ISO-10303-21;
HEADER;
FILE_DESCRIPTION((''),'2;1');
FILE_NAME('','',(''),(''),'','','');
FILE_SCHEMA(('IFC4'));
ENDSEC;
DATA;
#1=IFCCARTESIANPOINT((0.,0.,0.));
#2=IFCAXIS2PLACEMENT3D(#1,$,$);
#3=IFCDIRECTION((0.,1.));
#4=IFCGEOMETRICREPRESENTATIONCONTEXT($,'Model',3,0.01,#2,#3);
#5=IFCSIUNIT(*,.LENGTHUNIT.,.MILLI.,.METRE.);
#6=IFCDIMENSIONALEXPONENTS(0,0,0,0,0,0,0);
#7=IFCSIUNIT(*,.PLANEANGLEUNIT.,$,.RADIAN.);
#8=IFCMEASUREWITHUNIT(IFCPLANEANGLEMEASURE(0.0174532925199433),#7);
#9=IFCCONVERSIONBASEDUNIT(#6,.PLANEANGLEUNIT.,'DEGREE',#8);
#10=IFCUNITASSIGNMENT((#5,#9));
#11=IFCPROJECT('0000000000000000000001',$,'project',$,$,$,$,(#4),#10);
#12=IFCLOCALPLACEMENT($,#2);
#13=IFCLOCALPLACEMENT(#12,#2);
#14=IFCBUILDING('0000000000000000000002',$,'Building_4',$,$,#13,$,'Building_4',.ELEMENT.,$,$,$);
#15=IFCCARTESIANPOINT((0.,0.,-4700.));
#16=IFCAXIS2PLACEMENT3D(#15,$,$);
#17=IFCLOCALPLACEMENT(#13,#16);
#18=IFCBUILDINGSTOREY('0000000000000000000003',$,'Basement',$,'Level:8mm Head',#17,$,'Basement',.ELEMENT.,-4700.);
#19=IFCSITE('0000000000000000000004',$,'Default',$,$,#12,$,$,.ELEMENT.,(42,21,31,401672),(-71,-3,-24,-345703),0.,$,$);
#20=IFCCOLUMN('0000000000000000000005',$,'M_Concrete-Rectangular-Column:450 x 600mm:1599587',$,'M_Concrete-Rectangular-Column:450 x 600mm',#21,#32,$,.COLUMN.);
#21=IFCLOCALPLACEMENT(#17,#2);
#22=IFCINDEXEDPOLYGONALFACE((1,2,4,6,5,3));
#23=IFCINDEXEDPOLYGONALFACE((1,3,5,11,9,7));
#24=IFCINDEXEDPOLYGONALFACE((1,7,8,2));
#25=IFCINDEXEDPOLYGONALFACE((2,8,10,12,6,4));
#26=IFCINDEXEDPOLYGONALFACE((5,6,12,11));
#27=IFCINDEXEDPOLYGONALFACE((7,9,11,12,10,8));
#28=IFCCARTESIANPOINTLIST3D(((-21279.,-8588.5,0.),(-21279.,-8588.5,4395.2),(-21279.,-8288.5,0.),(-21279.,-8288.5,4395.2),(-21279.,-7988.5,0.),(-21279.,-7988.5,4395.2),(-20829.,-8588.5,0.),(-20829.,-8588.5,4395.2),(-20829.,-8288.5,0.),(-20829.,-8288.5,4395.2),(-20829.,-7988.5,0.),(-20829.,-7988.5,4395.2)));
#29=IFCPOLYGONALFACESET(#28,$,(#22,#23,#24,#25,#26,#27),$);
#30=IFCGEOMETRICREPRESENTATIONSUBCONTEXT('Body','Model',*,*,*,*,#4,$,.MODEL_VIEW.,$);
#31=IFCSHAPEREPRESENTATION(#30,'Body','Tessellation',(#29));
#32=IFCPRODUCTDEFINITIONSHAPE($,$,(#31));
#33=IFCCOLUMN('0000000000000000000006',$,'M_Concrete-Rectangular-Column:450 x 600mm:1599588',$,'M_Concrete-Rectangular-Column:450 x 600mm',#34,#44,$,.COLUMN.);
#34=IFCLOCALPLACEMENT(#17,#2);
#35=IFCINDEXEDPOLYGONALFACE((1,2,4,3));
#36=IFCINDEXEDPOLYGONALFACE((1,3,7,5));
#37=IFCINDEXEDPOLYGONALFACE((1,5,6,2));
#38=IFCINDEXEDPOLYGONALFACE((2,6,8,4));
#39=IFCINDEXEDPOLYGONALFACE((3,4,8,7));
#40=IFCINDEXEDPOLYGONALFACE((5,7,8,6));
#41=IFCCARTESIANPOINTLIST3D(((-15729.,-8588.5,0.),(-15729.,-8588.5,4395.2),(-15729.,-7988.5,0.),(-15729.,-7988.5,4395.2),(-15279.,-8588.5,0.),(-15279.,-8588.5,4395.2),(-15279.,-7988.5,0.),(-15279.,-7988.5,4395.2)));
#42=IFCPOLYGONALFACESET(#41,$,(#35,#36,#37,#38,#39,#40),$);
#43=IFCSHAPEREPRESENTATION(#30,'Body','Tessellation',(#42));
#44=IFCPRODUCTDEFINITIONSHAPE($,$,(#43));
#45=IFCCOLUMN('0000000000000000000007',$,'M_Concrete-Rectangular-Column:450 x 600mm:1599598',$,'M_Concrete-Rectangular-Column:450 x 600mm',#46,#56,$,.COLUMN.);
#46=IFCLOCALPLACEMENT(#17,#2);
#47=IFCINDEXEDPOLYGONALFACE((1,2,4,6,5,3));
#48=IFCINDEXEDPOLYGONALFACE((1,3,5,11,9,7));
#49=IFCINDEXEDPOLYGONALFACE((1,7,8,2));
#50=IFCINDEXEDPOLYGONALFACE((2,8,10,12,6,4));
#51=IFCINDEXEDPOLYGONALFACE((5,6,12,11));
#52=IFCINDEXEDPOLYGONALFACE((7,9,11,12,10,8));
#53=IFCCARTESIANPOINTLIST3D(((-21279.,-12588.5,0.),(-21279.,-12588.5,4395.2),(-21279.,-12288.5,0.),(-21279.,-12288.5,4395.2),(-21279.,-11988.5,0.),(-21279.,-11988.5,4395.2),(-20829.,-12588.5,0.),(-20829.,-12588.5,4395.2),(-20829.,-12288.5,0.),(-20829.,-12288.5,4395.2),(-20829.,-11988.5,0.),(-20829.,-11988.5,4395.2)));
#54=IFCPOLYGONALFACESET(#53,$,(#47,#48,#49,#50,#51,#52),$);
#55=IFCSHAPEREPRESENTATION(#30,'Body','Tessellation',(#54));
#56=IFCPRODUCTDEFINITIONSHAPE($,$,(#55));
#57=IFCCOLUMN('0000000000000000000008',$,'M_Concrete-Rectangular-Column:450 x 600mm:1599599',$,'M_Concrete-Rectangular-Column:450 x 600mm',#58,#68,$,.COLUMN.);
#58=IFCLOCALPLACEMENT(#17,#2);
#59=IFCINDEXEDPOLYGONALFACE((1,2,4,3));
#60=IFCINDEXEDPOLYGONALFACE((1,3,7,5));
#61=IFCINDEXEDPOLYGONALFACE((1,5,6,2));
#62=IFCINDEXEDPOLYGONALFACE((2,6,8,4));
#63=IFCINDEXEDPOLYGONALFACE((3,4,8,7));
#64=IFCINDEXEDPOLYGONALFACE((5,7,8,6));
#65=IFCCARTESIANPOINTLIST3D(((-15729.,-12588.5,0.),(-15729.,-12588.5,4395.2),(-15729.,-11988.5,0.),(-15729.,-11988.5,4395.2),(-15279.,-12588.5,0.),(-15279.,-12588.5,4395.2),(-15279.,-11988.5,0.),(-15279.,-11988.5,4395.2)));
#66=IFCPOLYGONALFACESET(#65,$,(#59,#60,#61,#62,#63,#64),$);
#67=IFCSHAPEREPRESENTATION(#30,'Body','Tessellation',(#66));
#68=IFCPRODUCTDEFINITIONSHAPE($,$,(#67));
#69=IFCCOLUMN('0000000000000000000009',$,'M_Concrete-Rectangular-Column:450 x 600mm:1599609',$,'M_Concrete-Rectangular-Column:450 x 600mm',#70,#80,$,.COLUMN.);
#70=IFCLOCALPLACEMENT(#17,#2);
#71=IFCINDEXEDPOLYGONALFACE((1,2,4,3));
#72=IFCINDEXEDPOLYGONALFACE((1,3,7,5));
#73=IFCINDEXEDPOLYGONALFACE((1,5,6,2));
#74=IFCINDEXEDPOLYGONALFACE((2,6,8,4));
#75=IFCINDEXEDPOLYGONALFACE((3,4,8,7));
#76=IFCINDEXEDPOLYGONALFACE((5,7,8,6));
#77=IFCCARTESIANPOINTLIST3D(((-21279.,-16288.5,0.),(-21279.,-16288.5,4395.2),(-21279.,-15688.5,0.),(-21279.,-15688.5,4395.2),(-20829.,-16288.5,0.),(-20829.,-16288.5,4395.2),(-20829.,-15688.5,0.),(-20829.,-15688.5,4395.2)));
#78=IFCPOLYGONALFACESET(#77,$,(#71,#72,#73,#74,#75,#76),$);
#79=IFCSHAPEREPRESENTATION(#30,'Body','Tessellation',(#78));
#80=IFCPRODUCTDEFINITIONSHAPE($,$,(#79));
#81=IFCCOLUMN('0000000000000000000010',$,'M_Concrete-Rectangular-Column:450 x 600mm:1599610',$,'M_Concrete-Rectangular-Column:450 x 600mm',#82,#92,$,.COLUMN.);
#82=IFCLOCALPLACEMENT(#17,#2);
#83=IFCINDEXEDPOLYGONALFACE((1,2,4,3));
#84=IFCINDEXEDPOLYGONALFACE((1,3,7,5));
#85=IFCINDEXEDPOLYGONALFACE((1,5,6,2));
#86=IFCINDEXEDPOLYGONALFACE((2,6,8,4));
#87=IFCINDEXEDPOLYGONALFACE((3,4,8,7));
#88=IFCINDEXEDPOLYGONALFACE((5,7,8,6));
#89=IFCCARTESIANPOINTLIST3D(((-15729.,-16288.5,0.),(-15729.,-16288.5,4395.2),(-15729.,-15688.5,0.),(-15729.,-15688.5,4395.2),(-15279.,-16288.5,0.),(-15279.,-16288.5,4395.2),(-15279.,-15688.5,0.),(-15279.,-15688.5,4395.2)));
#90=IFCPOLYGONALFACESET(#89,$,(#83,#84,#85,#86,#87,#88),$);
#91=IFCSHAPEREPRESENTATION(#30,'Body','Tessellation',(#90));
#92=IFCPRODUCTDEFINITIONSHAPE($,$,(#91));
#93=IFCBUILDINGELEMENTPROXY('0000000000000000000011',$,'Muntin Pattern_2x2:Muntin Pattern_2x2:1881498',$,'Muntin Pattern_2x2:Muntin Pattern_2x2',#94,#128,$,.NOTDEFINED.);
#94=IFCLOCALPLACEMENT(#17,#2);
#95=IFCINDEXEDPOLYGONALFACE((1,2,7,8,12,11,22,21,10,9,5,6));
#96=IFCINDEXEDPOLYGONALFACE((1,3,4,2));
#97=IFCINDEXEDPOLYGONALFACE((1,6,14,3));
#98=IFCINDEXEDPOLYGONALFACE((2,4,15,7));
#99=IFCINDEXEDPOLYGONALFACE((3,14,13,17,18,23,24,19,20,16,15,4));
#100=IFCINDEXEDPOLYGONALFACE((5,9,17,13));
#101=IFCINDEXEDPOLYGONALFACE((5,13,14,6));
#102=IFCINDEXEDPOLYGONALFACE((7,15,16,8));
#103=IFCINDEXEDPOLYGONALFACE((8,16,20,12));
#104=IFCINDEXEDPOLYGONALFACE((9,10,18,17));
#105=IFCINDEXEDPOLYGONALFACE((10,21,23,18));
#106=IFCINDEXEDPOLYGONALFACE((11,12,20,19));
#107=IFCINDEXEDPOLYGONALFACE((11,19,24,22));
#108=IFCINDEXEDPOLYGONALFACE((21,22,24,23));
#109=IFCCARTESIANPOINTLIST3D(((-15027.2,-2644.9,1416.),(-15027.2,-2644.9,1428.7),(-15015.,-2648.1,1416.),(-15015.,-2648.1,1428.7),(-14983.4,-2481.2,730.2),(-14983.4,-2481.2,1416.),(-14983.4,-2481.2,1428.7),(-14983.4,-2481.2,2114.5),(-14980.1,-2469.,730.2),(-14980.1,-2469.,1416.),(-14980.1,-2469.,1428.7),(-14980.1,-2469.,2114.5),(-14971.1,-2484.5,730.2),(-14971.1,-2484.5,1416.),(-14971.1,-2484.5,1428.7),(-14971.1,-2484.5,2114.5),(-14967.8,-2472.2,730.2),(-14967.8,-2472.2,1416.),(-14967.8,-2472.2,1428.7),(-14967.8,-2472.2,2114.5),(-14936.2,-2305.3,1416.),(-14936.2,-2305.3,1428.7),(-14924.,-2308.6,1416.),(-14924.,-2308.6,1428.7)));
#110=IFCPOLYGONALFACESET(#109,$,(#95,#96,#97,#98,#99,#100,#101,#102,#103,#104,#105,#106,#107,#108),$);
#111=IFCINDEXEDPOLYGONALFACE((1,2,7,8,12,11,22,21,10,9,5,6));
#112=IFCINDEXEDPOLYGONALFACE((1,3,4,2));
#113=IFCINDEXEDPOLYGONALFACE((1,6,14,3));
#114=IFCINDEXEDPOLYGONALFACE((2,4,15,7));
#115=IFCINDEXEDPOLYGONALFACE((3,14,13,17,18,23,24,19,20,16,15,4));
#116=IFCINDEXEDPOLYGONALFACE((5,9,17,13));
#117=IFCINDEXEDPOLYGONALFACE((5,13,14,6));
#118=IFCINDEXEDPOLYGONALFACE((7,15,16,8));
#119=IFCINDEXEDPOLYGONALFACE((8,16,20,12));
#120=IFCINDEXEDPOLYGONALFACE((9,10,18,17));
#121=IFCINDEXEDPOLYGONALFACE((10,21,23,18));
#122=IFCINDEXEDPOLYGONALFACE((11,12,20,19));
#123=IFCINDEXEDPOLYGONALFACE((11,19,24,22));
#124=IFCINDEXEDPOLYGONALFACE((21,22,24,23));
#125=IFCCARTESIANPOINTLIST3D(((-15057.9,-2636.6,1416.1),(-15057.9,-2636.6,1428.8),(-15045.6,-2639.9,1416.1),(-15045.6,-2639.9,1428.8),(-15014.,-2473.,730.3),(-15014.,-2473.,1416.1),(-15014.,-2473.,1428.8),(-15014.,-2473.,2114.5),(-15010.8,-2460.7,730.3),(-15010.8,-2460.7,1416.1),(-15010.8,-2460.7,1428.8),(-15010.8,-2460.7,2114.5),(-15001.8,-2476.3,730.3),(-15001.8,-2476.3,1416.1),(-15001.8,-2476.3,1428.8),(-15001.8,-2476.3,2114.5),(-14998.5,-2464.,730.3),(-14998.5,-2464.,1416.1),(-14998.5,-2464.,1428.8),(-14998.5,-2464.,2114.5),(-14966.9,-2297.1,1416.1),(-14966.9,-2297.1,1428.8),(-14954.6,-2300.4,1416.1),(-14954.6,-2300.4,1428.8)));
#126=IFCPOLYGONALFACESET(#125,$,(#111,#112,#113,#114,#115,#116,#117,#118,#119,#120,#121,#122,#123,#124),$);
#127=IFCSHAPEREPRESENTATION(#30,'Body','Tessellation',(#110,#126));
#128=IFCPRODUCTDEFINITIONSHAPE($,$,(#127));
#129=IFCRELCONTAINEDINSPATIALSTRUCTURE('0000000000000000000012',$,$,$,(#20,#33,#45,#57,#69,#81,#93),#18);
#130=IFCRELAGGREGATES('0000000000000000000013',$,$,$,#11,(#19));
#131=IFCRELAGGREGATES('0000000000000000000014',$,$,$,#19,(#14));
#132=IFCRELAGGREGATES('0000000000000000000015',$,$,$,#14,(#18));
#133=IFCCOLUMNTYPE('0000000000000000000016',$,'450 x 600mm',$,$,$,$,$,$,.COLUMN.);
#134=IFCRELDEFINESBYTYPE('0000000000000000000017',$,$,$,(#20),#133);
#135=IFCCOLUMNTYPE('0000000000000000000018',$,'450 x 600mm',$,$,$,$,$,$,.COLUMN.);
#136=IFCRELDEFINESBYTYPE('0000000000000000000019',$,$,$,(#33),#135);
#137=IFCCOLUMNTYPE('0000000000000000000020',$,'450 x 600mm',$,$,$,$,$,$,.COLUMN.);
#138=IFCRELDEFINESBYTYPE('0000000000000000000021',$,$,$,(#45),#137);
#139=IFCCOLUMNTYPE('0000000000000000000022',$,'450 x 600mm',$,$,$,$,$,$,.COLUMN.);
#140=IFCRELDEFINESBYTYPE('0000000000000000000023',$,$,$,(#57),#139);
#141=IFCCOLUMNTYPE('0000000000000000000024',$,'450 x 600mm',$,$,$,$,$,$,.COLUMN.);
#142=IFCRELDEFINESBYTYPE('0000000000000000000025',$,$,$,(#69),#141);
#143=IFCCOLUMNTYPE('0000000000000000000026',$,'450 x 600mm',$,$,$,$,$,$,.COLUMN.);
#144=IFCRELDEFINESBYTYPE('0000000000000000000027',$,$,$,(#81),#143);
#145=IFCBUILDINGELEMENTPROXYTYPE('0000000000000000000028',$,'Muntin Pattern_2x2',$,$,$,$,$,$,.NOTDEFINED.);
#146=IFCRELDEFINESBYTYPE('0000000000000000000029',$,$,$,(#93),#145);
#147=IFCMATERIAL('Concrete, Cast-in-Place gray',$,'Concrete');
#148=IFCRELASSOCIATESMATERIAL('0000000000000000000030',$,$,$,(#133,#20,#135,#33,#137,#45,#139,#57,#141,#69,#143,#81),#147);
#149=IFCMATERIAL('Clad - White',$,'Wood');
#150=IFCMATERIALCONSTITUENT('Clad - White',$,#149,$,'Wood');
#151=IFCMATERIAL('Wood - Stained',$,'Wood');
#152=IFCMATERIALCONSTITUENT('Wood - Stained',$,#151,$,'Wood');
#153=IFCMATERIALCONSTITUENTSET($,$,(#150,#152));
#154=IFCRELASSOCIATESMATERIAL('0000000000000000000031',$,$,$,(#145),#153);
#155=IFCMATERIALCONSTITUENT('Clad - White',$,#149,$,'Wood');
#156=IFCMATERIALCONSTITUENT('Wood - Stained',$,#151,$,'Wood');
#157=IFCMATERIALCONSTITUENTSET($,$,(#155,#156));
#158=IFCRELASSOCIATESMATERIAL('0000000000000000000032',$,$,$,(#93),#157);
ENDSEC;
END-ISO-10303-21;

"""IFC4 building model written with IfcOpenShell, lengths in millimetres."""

from ifc_helpers import new_model, entity, si_unit, converted_unit, direction, frame, origin, place, context, subcontext, project, spatial, indexed_curve, outline, extrude, source, transform, mapped, material, constituent, constituent_set, type_object, type_shapes, element, save


model = new_model("IFC4")

# Units and contexts
model_context = context("Model", 3, precision=0.01, world=origin(), true_north=direction((0.0, 1.0)))
body_context = subcontext(model_context, "Body", "Model", "MODEL_VIEW")
ifc_project = project(units=[si_unit("LENGTHUNIT", "METRE", prefix="MILLI"), converted_unit("PLANEANGLEUNIT", "DEGREE", entity("IfcPlaneAngleMeasure", 0.0174532925199433), si_unit("PLANEANGLEUNIT", "RADIAN"), dimensions=[0, 0, 0, 0, 0, 0, 0])], contexts=[model_context])

# Site, building, storey
site_placement = place(None, origin())
site = spatial("IfcSite", under=ifc_project, at=site_placement, Name="Default", CompositionType="ELEMENT", RefLatitude=(42, 21, 31, 401672), RefLongitude=(-71, -3, -24, -345703), RefElevation=0.0)
building_placement = place(site_placement, origin())
building = spatial("IfcBuilding", under=site, at=building_placement, Name="Building_4", LongName="Building_4", CompositionType="ELEMENT")
storey_placement = place(building_placement, frame((0.0, 0.0, -4700.0)))
storey = spatial("IfcBuildingStorey", under=building, at=storey_placement, Name="Basement", ObjectType="Level:8mm Head", LongName="Basement", CompositionType="ELEMENT", Elevation=-4700.0)

# Shared definitions
ifc_material_1 = material(Name="Concrete, Cast-in-Place gray", Category="Concrete")

# Columns
column_type_1 = type_object("IfcColumnType", Name="450 x 600mm", PredefinedType="COLUMN", material=ifc_material_1)
shared_shape_1 = source(origin(), body_context, "Body", "SweptSolid", [
    extrude(outline(indexed_curve([(-2197.6, -300.0), (2197.6, -300.0), (2197.6, 0.0), (2197.6, 300.0), (-2197.6, 300.0), (-2197.6, 0.0), (-2197.6, -300.0)], self_intersect=False)), frame((-21279.0, -8288.5, -2502.4), z_axis=(1.0, 0.0, 0.0), x_axis=(0.0, 0.0, 1.0)), (0.0, 0.0, 1.0), 450.0),
])
type_shapes(column_type_1, [shared_shape_1])
column_1_placement = place(storey_placement, frame((0.0, 0.0, 4700.0)))
element("IfcColumn", 1, at=column_1_placement, inside=storey, type_object=column_type_1, material=ifc_material_1, Name="M_Concrete-Rectangular-Column:450 x 600mm:1599587", ObjectType="M_Concrete-Rectangular-Column:450 x 600mm", PredefinedType="COLUMN", context=body_context, shape_type="MappedRepresentation", body=[
    mapped(shared_shape_1, transform((0.0, 0.0, 0.0), scale=1.0)),
])
column_type_2 = type_object("IfcColumnType", Name="450 x 600mm", PredefinedType="COLUMN", material=ifc_material_1)
shared_shape_2 = source(origin(), body_context, "Body", "SweptSolid", [
    extrude(outline(indexed_curve([(-2197.6, -300.0), (2197.6, -300.0), (2197.6, 300.0), (-2197.6, 300.0), (-2197.6, -300.0)], self_intersect=False)), frame((-15729.0, -8288.5, -2502.4), z_axis=(1.0, 0.0, 0.0), x_axis=(0.0, 0.0, 1.0)), (0.0, 0.0, 1.0), 450.0),
])
type_shapes(column_type_2, [shared_shape_2])
column_2_placement = place(storey_placement, frame((0.0, 0.0, 4700.0)))
element("IfcColumn", 2, at=column_2_placement, inside=storey, type_object=column_type_2, material=ifc_material_1, Name="M_Concrete-Rectangular-Column:450 x 600mm:1599588", ObjectType="M_Concrete-Rectangular-Column:450 x 600mm", PredefinedType="COLUMN", context=body_context, shape_type="MappedRepresentation", body=[
    mapped(shared_shape_2, transform((0.0, 0.0, 0.0), scale=1.0)),
])
column_type_3 = type_object("IfcColumnType", Name="450 x 600mm", PredefinedType="COLUMN", material=ifc_material_1)
shared_shape_3 = source(origin(), body_context, "Body", "SweptSolid", [
    extrude(outline(indexed_curve([(-2197.6, -300.0), (2197.6, -300.0), (2197.6, 0.0), (2197.6, 300.0), (-2197.6, 300.0), (-2197.6, 0.0), (-2197.6, -300.0)], self_intersect=False)), frame((-21279.0, -12288.5, -2502.4), z_axis=(1.0, 0.0, 0.0), x_axis=(0.0, 0.0, 1.0)), (0.0, 0.0, 1.0), 450.0),
])
type_shapes(column_type_3, [shared_shape_3])
column_3_placement = place(storey_placement, frame((0.0, 0.0, 4700.0)))
element("IfcColumn", 3, at=column_3_placement, inside=storey, type_object=column_type_3, material=ifc_material_1, Name="M_Concrete-Rectangular-Column:450 x 600mm:1599598", ObjectType="M_Concrete-Rectangular-Column:450 x 600mm", PredefinedType="COLUMN", context=body_context, shape_type="MappedRepresentation", body=[
    mapped(shared_shape_3, transform((0.0, 0.0, 0.0), scale=1.0)),
])
column_type_4 = type_object("IfcColumnType", Name="450 x 600mm", PredefinedType="COLUMN", material=ifc_material_1)
shared_shape_4 = source(origin(), body_context, "Body", "SweptSolid", [
    extrude(outline(indexed_curve([(-2197.6, -300.0), (2197.6, -300.0), (2197.6, 300.0), (-2197.6, 300.0), (-2197.6, -300.0)], self_intersect=False)), frame((-15729.0, -12288.5, -2502.4), z_axis=(1.0, 0.0, 0.0), x_axis=(0.0, 0.0, 1.0)), (0.0, 0.0, 1.0), 450.0),
])
type_shapes(column_type_4, [shared_shape_4])
column_4_placement = place(storey_placement, frame((0.0, 0.0, 4700.0)))
element("IfcColumn", 4, at=column_4_placement, inside=storey, type_object=column_type_4, material=ifc_material_1, Name="M_Concrete-Rectangular-Column:450 x 600mm:1599599", ObjectType="M_Concrete-Rectangular-Column:450 x 600mm", PredefinedType="COLUMN", context=body_context, shape_type="MappedRepresentation", body=[
    mapped(shared_shape_4, transform((0.0, 0.0, 0.0), scale=1.0)),
])
column_type_5 = type_object("IfcColumnType", Name="450 x 600mm", PredefinedType="COLUMN", material=ifc_material_1)
shared_shape_5 = source(origin(), body_context, "Body", "SweptSolid", [
    extrude(outline(indexed_curve([(-2197.6, -300.0), (2197.6, -300.0), (2197.6, 300.0), (-2197.6, 300.0), (-2197.6, -300.0)], self_intersect=False)), frame((-21279.0, -15988.5, -2502.4), z_axis=(1.0, 0.0, 0.0), x_axis=(0.0, 0.0, 1.0)), (0.0, 0.0, 1.0), 450.0),
])
type_shapes(column_type_5, [shared_shape_5])
column_5_placement = place(storey_placement, frame((0.0, 0.0, 4700.0)))
element("IfcColumn", 5, at=column_5_placement, inside=storey, type_object=column_type_5, material=ifc_material_1, Name="M_Concrete-Rectangular-Column:450 x 600mm:1599609", ObjectType="M_Concrete-Rectangular-Column:450 x 600mm", PredefinedType="COLUMN", context=body_context, shape_type="MappedRepresentation", body=[
    mapped(shared_shape_5, transform((0.0, 0.0, 0.0), scale=1.0)),
])
column_type_6 = type_object("IfcColumnType", Name="450 x 600mm", PredefinedType="COLUMN", material=ifc_material_1)
shared_shape_6 = source(origin(), body_context, "Body", "SweptSolid", [
    extrude(outline(indexed_curve([(-2197.6, -300.0), (2197.6, -300.0), (2197.6, 300.0), (-2197.6, 300.0), (-2197.6, -300.0)], self_intersect=False)), frame((-15729.0, -15988.5, -2502.4), z_axis=(1.0, 0.0, 0.0), x_axis=(0.0, 0.0, 1.0)), (0.0, 0.0, 1.0), 450.0),
])
type_shapes(column_type_6, [shared_shape_6])
column_6_placement = place(storey_placement, frame((0.0, 0.0, 4700.0)))
element("IfcColumn", 6, at=column_6_placement, inside=storey, type_object=column_type_6, material=ifc_material_1, Name="M_Concrete-Rectangular-Column:450 x 600mm:1599610", ObjectType="M_Concrete-Rectangular-Column:450 x 600mm", PredefinedType="COLUMN", context=body_context, shape_type="MappedRepresentation", body=[
    mapped(shared_shape_6, transform((0.0, 0.0, 0.0), scale=1.0)),
])

# Building element proxy
ifc_material_2 = material(Name="Clad - White", Category="Wood")
ifc_constituent_1 = constituent(ifc_material_2, Name="Clad - White", Category="Wood")
ifc_material_3 = material(Name="Wood - Stained", Category="Wood")
ifc_constituent_2 = constituent(ifc_material_3, Name="Wood - Stained", Category="Wood")
ifc_constituent_set_1 = constituent_set(constituents=[ifc_constituent_1, ifc_constituent_2])
ifc_constituent_3 = constituent(ifc_material_2, Name="Clad - White", Category="Wood")
ifc_constituent_4 = constituent(ifc_material_3, Name="Wood - Stained", Category="Wood")
ifc_constituent_set_2 = constituent_set(constituents=[ifc_constituent_3, ifc_constituent_4])
building_element_proxy_type = type_object("IfcBuildingElementProxyType", Name="Muntin Pattern_2x2", PredefinedType="NOTDEFINED", material=ifc_constituent_set_2)
shared_shape_7 = source(origin(), body_context, "Body", "SweptSolid", [
    extrude(outline(indexed_curve([(6.4, -6.4), (692.1, -6.4), (692.1, 6.3), (6.4, 6.3), (6.4, 175.8), (-6.3, 175.8), (-6.3, 6.3), (-692.2, 6.3), (-692.2, -6.4), (-6.3, -6.4), (-6.3, -175.8), (6.4, -175.8), (6.4, -6.4)], self_intersect=False)), frame((0.0, -22.2, 692.1), z_axis=(0.0, 1.0, 0.0), x_axis=(0.0, 0.0, 1.0)), (0.0, 0.0, 1.0), 12.7),
    extrude(outline(indexed_curve([(6.4, -6.4), (692.1, -6.4), (692.1, 6.3), (6.4, 6.3), (6.4, 175.8), (-6.3, 175.8), (-6.3, 6.3), (-692.1, 6.3), (-692.1, -6.4), (-6.3, -6.4), (-6.3, -175.8), (6.4, -175.8), (6.4, -6.4)], self_intersect=False)), frame((0.0, 9.5, 692.1), z_axis=(0.0, 1.0, 0.0), x_axis=(0.0, 0.0, 1.0)), (0.0, 0.0, 1.0), 12.7),
])
type_shapes(building_element_proxy_type, [shared_shape_7])
proxy_1_placement = place(storey_placement, frame((-14990.9, -2472.6, 730.3), z_axis=(0.0, 0.0, 1.0), x_axis=(0.258819, 0.965926, 0.0)))
element("IfcBuildingElementProxy", 7, at=proxy_1_placement, inside=storey, type_object=building_element_proxy_type, material=ifc_constituent_set_1, Name="Muntin Pattern_2x2:Muntin Pattern_2x2:1881498", ObjectType="Muntin Pattern_2x2:Muntin Pattern_2x2", PredefinedType="NOTDEFINED", context=body_context, shape_type="MappedRepresentation", body=[
    mapped(shared_shape_7, transform((0.0, 0.0, 0.0), scale=1.0)),
])

save(model, "model.ifc")
